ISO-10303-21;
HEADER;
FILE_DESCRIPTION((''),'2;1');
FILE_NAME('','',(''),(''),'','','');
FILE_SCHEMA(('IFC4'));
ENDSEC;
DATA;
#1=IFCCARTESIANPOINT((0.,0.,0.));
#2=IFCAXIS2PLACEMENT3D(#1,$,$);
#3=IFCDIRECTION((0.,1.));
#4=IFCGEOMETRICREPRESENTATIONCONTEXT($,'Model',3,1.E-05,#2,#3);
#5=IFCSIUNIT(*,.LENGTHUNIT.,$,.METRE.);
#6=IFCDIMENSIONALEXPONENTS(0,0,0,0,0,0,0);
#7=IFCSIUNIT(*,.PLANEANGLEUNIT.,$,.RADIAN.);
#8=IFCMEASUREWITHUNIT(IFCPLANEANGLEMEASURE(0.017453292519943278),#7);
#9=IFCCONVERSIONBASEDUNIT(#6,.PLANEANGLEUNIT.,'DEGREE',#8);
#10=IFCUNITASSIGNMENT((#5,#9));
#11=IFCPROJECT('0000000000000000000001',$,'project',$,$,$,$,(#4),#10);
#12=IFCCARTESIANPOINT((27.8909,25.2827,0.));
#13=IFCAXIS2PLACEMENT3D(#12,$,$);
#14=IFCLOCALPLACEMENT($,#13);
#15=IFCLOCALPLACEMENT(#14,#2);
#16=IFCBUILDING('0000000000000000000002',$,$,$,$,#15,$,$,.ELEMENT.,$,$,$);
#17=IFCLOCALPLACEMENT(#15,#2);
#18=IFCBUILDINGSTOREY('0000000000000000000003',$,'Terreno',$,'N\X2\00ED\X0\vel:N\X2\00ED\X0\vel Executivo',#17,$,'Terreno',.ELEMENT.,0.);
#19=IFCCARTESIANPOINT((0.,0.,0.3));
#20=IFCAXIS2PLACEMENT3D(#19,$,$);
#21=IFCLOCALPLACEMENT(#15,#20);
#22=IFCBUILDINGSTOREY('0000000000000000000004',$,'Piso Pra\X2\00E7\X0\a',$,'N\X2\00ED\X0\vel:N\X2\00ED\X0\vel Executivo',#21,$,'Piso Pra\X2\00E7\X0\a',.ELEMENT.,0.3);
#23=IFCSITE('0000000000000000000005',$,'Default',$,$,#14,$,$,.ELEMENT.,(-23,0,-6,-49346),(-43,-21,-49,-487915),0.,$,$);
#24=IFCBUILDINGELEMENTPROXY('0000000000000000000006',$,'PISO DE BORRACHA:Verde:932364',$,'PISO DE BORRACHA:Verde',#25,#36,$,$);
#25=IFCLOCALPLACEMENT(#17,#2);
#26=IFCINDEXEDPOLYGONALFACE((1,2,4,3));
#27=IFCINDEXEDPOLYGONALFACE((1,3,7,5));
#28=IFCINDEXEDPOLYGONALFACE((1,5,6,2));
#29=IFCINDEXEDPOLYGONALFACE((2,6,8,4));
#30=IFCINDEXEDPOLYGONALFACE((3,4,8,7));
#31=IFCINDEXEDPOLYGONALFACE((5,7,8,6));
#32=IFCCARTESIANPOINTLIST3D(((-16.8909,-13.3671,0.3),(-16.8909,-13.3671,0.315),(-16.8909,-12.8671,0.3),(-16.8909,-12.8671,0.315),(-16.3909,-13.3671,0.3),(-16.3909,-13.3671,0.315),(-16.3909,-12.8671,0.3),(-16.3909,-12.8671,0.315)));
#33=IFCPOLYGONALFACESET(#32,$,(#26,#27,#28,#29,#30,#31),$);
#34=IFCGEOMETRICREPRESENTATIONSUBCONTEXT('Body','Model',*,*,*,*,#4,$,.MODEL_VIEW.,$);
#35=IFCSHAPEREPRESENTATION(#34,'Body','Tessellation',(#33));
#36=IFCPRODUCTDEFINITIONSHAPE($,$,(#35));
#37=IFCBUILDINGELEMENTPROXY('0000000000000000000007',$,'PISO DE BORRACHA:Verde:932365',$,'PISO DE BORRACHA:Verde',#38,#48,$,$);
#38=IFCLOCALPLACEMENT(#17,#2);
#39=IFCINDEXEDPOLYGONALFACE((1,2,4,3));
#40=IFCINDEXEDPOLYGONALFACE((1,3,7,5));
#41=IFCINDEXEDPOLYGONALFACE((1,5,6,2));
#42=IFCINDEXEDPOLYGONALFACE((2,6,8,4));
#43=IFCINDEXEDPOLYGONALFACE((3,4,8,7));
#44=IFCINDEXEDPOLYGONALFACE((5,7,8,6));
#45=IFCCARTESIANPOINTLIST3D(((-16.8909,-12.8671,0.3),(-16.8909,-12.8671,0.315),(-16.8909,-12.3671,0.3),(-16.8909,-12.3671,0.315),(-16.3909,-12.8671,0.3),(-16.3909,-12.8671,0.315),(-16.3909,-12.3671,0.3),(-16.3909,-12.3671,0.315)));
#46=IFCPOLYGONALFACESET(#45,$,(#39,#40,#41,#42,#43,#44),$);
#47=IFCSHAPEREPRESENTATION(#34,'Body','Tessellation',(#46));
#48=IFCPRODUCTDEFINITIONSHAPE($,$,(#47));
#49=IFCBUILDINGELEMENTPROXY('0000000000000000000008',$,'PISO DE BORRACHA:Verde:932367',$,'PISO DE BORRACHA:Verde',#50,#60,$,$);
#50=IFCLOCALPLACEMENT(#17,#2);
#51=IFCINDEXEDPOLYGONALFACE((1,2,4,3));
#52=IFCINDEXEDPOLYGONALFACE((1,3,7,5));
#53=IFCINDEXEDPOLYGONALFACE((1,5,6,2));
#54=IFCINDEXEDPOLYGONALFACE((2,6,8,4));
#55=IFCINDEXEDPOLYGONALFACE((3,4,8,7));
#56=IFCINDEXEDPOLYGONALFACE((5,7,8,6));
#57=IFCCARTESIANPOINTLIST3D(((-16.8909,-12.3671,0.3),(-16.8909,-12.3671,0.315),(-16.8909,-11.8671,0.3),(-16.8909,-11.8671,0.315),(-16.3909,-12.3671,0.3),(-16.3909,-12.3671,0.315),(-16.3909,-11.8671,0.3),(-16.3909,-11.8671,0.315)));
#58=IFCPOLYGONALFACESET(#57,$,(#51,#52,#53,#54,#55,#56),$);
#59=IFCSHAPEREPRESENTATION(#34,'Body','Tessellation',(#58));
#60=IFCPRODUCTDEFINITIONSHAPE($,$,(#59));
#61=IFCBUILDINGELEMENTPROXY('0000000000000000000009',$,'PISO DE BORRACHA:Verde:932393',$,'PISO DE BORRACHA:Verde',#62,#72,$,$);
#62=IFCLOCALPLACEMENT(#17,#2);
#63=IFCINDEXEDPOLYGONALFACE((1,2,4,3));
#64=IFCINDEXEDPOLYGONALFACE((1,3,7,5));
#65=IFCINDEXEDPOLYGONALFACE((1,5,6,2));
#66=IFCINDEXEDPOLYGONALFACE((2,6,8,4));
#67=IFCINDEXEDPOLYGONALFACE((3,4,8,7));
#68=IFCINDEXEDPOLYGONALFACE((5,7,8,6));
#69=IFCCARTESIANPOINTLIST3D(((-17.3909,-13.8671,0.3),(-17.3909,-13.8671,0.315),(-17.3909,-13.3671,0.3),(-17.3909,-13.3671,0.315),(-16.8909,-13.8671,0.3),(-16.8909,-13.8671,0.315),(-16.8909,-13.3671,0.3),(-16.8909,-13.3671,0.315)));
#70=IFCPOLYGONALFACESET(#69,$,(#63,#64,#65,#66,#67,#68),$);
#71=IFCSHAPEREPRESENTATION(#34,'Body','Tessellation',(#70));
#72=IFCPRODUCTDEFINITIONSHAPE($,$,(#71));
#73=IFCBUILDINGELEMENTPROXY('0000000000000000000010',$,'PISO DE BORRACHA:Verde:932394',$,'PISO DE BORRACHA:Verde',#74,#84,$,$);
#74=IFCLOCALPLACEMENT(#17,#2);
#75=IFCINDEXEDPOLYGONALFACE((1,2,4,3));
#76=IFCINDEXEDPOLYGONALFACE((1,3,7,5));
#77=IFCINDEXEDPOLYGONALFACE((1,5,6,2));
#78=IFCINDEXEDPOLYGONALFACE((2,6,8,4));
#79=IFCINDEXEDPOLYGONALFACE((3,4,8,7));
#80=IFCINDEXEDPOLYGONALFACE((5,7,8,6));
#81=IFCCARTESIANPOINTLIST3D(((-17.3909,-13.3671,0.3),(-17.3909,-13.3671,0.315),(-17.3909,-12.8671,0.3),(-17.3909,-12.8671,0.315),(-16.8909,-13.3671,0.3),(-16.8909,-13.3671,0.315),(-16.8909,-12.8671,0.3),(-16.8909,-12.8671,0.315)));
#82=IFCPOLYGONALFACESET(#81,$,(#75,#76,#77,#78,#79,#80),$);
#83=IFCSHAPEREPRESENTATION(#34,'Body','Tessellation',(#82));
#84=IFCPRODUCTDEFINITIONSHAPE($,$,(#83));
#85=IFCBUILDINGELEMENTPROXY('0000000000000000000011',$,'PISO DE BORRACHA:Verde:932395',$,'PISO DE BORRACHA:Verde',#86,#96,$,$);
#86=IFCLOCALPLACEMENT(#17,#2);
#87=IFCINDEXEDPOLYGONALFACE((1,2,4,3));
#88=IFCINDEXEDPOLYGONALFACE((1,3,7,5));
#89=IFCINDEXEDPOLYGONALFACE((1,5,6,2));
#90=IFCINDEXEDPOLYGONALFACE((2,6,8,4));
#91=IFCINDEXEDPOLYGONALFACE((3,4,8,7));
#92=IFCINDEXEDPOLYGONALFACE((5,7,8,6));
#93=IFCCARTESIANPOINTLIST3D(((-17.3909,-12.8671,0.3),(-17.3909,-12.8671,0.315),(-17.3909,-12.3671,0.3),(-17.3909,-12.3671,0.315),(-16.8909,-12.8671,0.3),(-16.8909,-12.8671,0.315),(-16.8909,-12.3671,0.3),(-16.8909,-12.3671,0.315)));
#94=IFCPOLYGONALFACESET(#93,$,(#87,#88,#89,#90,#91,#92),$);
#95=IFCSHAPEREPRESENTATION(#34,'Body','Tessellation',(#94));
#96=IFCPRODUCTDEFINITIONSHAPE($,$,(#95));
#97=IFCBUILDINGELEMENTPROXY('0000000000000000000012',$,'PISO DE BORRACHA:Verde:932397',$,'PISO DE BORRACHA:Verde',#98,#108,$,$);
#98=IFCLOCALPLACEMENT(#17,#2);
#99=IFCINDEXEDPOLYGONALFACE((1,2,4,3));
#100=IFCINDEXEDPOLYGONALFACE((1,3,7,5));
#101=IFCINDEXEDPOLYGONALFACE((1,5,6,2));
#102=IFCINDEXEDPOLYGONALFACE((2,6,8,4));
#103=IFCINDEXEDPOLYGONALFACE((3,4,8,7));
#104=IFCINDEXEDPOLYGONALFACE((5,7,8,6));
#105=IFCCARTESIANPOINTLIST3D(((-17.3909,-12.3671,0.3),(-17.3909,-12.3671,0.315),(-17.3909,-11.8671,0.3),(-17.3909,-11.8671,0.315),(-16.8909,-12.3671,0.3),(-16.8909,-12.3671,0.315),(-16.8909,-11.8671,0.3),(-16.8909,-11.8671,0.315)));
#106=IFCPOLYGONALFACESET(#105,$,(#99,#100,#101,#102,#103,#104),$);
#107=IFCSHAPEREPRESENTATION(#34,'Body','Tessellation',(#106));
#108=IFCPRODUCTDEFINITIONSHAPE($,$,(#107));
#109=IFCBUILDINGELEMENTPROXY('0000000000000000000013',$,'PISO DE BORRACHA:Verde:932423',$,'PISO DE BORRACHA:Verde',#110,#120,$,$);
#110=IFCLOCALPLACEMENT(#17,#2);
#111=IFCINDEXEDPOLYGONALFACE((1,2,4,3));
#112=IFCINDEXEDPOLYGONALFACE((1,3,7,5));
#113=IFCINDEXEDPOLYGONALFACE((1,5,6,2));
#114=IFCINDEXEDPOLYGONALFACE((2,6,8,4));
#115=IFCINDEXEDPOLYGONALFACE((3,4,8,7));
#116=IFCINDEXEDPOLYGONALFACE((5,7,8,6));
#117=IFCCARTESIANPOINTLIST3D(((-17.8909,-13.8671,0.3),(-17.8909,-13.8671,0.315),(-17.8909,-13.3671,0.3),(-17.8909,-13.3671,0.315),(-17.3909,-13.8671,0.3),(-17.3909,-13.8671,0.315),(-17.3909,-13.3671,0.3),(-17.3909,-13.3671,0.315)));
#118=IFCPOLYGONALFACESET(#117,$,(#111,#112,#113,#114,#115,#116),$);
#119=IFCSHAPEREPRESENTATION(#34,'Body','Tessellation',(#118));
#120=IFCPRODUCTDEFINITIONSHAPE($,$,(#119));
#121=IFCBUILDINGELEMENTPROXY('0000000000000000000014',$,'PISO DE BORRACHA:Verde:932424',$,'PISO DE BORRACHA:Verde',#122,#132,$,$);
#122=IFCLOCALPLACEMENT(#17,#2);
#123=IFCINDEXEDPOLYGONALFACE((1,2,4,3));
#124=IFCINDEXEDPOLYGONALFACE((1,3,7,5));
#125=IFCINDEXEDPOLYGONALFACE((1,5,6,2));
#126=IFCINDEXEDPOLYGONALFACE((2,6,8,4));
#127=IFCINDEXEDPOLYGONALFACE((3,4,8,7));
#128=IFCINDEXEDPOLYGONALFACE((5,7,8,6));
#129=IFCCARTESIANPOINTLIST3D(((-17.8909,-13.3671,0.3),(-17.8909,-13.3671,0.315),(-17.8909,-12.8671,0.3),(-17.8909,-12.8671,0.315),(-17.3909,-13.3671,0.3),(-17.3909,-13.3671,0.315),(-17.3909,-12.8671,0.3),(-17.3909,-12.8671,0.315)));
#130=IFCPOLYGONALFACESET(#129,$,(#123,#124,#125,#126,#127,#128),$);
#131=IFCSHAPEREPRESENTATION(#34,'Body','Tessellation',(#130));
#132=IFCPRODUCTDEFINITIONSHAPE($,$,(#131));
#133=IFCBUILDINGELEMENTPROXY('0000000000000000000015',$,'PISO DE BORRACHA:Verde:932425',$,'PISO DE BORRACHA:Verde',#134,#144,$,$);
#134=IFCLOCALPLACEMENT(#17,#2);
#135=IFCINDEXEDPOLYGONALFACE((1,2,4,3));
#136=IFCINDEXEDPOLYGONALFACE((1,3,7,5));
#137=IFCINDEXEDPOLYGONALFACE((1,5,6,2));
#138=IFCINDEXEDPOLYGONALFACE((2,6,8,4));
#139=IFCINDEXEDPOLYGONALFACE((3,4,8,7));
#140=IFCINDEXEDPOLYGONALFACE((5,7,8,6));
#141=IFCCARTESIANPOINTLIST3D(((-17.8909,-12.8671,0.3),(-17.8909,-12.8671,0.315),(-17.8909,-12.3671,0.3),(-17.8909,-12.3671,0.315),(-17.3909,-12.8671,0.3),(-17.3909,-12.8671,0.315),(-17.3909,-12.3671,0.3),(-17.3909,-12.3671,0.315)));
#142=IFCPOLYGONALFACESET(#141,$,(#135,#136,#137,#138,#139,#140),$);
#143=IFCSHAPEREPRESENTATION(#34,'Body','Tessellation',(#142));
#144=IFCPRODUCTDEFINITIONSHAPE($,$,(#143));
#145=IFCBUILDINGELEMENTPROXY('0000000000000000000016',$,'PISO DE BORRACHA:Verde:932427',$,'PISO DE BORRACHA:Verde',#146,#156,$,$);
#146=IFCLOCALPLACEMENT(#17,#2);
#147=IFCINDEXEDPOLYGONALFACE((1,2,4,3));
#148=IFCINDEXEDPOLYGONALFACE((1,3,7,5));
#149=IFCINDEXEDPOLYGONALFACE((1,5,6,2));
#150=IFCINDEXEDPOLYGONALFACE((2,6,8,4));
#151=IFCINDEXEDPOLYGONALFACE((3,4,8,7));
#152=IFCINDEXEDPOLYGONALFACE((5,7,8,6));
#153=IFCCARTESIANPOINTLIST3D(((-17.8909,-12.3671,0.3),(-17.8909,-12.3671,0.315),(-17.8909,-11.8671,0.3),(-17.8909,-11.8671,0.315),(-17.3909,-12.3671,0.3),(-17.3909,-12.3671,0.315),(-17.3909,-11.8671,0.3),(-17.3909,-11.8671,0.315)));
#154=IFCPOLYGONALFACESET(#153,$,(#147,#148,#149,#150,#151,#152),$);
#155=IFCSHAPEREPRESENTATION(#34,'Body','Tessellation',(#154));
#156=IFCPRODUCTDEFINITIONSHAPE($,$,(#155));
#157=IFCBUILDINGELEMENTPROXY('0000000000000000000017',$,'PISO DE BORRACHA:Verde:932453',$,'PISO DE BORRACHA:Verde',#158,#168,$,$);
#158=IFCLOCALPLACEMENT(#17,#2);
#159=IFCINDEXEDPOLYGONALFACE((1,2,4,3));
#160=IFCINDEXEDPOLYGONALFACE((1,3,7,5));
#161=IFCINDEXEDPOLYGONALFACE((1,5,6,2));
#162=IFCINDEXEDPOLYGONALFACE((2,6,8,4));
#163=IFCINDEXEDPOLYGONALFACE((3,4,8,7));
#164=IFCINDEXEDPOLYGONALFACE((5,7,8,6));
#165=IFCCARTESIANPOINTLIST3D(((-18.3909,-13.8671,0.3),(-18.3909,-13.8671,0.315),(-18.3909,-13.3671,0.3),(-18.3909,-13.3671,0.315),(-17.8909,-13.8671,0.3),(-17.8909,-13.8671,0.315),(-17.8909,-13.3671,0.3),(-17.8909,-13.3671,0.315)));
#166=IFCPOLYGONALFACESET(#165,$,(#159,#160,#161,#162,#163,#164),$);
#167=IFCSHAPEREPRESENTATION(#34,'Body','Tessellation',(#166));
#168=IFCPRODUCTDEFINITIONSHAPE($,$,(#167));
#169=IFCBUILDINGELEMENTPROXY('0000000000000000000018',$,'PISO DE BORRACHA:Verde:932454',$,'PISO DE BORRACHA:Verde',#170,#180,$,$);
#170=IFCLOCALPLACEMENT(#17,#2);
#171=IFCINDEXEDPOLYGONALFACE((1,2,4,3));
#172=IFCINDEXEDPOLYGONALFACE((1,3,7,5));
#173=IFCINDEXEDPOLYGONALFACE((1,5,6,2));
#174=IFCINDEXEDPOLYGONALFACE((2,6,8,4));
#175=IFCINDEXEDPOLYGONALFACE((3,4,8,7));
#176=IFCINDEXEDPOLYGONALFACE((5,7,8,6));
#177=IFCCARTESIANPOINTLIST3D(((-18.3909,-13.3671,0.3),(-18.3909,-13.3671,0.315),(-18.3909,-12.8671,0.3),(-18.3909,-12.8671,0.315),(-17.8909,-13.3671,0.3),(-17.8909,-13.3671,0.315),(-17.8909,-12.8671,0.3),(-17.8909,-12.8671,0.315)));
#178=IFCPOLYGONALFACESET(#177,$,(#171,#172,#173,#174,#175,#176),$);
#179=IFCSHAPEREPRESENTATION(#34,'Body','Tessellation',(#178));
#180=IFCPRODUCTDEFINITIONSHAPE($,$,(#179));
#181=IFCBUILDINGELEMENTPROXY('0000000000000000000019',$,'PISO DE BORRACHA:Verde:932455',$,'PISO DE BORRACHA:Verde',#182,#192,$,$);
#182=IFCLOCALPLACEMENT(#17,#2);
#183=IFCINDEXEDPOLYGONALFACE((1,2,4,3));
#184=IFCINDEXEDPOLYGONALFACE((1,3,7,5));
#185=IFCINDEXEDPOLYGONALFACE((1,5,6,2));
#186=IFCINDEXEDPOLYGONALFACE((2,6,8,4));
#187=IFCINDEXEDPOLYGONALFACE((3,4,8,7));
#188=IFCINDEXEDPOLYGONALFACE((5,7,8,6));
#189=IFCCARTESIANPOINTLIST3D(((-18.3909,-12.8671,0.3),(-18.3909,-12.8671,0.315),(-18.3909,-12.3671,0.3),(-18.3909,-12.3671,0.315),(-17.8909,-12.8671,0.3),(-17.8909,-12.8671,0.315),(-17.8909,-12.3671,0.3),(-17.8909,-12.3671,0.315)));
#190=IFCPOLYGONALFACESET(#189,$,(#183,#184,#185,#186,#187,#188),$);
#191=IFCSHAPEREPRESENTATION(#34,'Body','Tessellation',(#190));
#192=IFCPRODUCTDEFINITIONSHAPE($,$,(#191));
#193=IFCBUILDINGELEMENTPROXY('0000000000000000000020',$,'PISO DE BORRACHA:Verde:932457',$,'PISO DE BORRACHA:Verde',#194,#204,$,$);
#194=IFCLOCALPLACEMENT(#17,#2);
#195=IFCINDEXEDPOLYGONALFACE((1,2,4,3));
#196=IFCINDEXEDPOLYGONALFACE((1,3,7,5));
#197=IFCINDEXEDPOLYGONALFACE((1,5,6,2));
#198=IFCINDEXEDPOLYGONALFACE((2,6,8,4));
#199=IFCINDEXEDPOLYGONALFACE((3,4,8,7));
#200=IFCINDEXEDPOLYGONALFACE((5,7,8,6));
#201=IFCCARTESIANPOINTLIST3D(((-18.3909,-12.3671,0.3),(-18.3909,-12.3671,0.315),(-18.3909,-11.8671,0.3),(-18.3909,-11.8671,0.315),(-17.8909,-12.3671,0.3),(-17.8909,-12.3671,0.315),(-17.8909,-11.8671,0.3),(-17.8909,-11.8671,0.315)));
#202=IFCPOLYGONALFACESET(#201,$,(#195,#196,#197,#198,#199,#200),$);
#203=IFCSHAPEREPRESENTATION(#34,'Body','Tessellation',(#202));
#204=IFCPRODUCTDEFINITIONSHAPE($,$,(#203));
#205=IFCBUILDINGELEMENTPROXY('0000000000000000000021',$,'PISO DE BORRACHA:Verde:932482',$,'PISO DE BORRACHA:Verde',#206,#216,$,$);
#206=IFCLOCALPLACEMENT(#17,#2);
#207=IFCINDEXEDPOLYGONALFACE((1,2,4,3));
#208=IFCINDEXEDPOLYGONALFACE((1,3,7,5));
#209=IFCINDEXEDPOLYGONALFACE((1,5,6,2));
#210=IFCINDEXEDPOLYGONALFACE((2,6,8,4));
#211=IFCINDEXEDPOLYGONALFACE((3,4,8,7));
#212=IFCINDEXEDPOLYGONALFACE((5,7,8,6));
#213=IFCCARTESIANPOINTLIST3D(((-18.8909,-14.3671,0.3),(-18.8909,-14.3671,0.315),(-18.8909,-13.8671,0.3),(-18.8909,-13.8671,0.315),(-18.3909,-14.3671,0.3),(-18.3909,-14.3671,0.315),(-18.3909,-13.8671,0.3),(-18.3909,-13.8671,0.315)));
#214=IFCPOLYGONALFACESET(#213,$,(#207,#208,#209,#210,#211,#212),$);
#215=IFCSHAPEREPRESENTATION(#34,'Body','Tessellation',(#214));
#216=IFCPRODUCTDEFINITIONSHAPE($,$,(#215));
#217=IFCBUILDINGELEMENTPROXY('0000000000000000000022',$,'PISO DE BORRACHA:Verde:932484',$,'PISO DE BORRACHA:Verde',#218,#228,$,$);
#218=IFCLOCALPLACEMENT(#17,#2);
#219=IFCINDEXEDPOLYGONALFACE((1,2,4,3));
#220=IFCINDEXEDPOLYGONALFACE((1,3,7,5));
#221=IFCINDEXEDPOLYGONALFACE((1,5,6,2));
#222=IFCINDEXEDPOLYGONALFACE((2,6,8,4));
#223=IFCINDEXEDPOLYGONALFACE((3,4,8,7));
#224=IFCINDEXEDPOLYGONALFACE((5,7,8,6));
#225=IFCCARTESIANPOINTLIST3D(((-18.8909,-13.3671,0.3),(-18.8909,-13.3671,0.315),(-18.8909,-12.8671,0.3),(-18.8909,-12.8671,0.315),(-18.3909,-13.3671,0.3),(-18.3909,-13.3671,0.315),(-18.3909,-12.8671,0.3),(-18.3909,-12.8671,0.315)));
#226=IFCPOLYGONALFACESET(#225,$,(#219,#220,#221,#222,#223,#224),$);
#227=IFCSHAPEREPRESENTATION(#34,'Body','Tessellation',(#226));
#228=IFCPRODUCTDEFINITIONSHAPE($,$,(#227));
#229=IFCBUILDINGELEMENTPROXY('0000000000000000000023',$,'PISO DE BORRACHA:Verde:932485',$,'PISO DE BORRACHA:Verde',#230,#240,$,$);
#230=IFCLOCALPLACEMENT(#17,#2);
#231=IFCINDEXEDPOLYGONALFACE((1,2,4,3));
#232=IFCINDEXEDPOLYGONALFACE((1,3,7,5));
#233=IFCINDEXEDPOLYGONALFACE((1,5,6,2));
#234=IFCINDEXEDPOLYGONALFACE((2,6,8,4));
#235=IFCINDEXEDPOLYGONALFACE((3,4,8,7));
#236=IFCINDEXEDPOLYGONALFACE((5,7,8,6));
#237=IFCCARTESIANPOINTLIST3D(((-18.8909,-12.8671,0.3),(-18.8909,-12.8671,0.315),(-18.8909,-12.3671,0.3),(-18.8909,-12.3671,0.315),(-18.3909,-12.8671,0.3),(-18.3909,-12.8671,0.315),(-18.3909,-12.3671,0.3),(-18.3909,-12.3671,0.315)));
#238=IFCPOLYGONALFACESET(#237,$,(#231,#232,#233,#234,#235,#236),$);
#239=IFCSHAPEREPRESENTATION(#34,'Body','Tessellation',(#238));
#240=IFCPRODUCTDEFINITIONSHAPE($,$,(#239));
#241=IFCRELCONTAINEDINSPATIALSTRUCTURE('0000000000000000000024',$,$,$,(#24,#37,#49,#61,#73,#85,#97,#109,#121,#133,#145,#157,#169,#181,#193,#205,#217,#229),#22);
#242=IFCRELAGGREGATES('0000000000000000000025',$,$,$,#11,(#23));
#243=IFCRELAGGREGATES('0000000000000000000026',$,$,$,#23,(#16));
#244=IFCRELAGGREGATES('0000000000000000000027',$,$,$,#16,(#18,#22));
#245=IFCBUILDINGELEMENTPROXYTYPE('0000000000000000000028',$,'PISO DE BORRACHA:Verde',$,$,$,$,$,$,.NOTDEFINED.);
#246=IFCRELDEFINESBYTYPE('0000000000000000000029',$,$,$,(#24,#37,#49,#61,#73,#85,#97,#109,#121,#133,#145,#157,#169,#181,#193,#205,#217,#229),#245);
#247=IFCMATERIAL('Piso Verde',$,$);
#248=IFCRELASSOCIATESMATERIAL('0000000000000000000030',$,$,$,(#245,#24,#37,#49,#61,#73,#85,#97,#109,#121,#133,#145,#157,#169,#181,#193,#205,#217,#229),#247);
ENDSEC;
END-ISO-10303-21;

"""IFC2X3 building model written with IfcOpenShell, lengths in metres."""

from ifc_helpers import new_model, entity, si_unit, converted_unit, direction, frame, origin, origin_2d_with_axis, place, context, subcontext, project, spatial, rectangle, extrude, source, transform, mapped, material, type_object, type_shapes, element, save


model = new_model("IFC2X3")

# Units and contexts
model_context = context("Model", 3, precision=1e-05, world=origin(), true_north=direction((0.0, 1.0)))
body_context = subcontext(model_context, "Body", "Model", "MODEL_VIEW")
ifc_project = project(units=[si_unit("LENGTHUNIT", "METRE"), converted_unit("PLANEANGLEUNIT", "DEGREE", entity("IfcPlaneAngleMeasure", 0.017453292519943278), si_unit("PLANEANGLEUNIT", "RADIAN"), dimensions=[0, 0, 0, 0, 0, 0, 0])], contexts=[model_context])

# Site, building, storey
site_placement = place(None, frame((27.8909, 25.2827, 0.0)))
site = spatial("IfcSite", under=ifc_project, at=site_placement, Name="Default", CompositionType="ELEMENT", RefLatitude=(-23, 0, -6, -49346), RefLongitude=(-43, -21, -49, -487915), RefElevation=0.0)
building_placement = place(site_placement, origin())
building = spatial("IfcBuilding", under=site, at=building_placement, CompositionType="ELEMENT")
storey_1_placement = place(building_placement, origin())
storey_1 = spatial("IfcBuildingStorey", under=building, at=storey_1_placement, Name="Terreno", ObjectType="Nível:Nível Executivo", LongName="Terreno", CompositionType="ELEMENT", Elevation=0.0)

# Shared definitions
storey_2_placement = place(building_placement, frame((0.0, 0.0, 0.3)))
storey_2 = spatial("IfcBuildingStorey", under=building, at=storey_2_placement, Name="Piso Praça", ObjectType="Nível:Nível Executivo", LongName="Piso Praça", CompositionType="ELEMENT", Elevation=0.3)

# Building element proxies
ifc_material_1 = material(Name="Piso Verde")
building_element_proxy_type_1 = type_object("IfcBuildingElementProxyType", Name="PISO DE BORRACHA:Verde", PredefinedType="NOTDEFINED", material=ifc_material_1)
shared_shape_1 = source(origin(), body_context, "Body", "SweptSolid", [
    extrude(rectangle(XDim=0.5, YDim=0.5, at=origin_2d_with_axis()), frame((0.25, 0.25, 0.0), z_axis=(0.0, 0.0, 1.0), x_axis=(-1.0, 0.0, 0.0)), (0.0, 0.0, 1.0), 0.015),
])
type_shapes(building_element_proxy_type_1, [shared_shape_1])
for number, where, z_axis, x_axis, name in (
    (1, (-16.8909, -12.8671, 0.0), (0.0, 0.0, 1.0), (0.0, -1.0, 0.0), "PISO DE BORRACHA:Verde:932364"),
    (2, (-16.8909, -12.3671, 0.0), (0.0, 0.0, 1.0), (0.0, -1.0, 0.0), "PISO DE BORRACHA:Verde:932365"),
    (3, (-16.8909, -11.8671, 0.0), (0.0, 0.0, 1.0), (0.0, -1.0, 0.0), "PISO DE BORRACHA:Verde:932367"),
    (4, (-17.3909, -13.3671, 0.0), (0.0, 0.0, 1.0), (0.0, -1.0, 0.0), "PISO DE BORRACHA:Verde:932393"),
    (5, (-17.3909, -12.8671, 0.0), (0.0, 0.0, 1.0), (0.0, -1.0, 0.0), "PISO DE BORRACHA:Verde:932394"),
    (6, (-17.3909, -12.3671, 0.0), (0.0, 0.0, 1.0), (0.0, -1.0, 0.0), "PISO DE BORRACHA:Verde:932395"),
    (7, (-17.3909, -11.8671, 0.0), (0.0, 0.0, 1.0), (0.0, -1.0, 0.0), "PISO DE BORRACHA:Verde:932397"),
    (8, (-17.8909, -13.3671, 0.0), (0.0, 0.0, 1.0), (0.0, -1.0, 0.0), "PISO DE BORRACHA:Verde:932423"),
    (9, (-17.8909, -12.8671, 0.0), (0.0, 0.0, 1.0), (0.0, -1.0, 0.0), "PISO DE BORRACHA:Verde:932424"),
    (10, (-17.8909, -12.3671, 0.0), (0.0, 0.0, 1.0), (0.0, -1.0, 0.0), "PISO DE BORRACHA:Verde:932425"),
    (11, (-17.8909, -11.8671, 0.0), (0.0, 0.0, 1.0), (0.0, -1.0, 0.0), "PISO DE BORRACHA:Verde:932427"),
    (12, (-18.3909, -13.3671, 0.0), (0.0, 0.0, 1.0), (0.0, -1.0, 0.0), "PISO DE BORRACHA:Verde:932453"),
    (13, (-18.3909, -12.8671, 0.0), (0.0, 0.0, 1.0), (0.0, -1.0, 0.0), "PISO DE BORRACHA:Verde:932454"),
    (14, (-18.3909, -12.3671, 0.0), (0.0, 0.0, 1.0), (0.0, -1.0, 0.0), "PISO DE BORRACHA:Verde:932455"),
    (15, (-18.3909, -11.8671, 0.0), (0.0, 0.0, 1.0), (0.0, -1.0, 0.0), "PISO DE BORRACHA:Verde:932457"),
    (16, (-18.8909, -13.8671, 0.0), (0.0, 0.0, 1.0), (0.0, -1.0, 0.0), "PISO DE BORRACHA:Verde:932482"),
    (17, (-18.8909, -12.8671, 0.0), (0.0, 0.0, 1.0), (0.0, -1.0, 0.0), "PISO DE BORRACHA:Verde:932484"),
    (18, (-18.8909, -12.3671, 0.0), (0.0, 0.0, 1.0), (0.0, -1.0, 0.0), "PISO DE BORRACHA:Verde:932485"),
):
    element("IfcBuildingElementProxy", number, at=place(storey_2_placement, frame(where, z_axis=z_axis, x_axis=x_axis)), inside=storey_2, type_object=building_element_proxy_type_1, material=ifc_material_1, Name=name, ObjectType="PISO DE BORRACHA:Verde", context=body_context, shape_type="MappedRepresentation", body=[
        mapped(shared_shape_1, transform((0.0, 0.0, 0.0), scale=1.0)),
    ])

save(model, "model.ifc")
